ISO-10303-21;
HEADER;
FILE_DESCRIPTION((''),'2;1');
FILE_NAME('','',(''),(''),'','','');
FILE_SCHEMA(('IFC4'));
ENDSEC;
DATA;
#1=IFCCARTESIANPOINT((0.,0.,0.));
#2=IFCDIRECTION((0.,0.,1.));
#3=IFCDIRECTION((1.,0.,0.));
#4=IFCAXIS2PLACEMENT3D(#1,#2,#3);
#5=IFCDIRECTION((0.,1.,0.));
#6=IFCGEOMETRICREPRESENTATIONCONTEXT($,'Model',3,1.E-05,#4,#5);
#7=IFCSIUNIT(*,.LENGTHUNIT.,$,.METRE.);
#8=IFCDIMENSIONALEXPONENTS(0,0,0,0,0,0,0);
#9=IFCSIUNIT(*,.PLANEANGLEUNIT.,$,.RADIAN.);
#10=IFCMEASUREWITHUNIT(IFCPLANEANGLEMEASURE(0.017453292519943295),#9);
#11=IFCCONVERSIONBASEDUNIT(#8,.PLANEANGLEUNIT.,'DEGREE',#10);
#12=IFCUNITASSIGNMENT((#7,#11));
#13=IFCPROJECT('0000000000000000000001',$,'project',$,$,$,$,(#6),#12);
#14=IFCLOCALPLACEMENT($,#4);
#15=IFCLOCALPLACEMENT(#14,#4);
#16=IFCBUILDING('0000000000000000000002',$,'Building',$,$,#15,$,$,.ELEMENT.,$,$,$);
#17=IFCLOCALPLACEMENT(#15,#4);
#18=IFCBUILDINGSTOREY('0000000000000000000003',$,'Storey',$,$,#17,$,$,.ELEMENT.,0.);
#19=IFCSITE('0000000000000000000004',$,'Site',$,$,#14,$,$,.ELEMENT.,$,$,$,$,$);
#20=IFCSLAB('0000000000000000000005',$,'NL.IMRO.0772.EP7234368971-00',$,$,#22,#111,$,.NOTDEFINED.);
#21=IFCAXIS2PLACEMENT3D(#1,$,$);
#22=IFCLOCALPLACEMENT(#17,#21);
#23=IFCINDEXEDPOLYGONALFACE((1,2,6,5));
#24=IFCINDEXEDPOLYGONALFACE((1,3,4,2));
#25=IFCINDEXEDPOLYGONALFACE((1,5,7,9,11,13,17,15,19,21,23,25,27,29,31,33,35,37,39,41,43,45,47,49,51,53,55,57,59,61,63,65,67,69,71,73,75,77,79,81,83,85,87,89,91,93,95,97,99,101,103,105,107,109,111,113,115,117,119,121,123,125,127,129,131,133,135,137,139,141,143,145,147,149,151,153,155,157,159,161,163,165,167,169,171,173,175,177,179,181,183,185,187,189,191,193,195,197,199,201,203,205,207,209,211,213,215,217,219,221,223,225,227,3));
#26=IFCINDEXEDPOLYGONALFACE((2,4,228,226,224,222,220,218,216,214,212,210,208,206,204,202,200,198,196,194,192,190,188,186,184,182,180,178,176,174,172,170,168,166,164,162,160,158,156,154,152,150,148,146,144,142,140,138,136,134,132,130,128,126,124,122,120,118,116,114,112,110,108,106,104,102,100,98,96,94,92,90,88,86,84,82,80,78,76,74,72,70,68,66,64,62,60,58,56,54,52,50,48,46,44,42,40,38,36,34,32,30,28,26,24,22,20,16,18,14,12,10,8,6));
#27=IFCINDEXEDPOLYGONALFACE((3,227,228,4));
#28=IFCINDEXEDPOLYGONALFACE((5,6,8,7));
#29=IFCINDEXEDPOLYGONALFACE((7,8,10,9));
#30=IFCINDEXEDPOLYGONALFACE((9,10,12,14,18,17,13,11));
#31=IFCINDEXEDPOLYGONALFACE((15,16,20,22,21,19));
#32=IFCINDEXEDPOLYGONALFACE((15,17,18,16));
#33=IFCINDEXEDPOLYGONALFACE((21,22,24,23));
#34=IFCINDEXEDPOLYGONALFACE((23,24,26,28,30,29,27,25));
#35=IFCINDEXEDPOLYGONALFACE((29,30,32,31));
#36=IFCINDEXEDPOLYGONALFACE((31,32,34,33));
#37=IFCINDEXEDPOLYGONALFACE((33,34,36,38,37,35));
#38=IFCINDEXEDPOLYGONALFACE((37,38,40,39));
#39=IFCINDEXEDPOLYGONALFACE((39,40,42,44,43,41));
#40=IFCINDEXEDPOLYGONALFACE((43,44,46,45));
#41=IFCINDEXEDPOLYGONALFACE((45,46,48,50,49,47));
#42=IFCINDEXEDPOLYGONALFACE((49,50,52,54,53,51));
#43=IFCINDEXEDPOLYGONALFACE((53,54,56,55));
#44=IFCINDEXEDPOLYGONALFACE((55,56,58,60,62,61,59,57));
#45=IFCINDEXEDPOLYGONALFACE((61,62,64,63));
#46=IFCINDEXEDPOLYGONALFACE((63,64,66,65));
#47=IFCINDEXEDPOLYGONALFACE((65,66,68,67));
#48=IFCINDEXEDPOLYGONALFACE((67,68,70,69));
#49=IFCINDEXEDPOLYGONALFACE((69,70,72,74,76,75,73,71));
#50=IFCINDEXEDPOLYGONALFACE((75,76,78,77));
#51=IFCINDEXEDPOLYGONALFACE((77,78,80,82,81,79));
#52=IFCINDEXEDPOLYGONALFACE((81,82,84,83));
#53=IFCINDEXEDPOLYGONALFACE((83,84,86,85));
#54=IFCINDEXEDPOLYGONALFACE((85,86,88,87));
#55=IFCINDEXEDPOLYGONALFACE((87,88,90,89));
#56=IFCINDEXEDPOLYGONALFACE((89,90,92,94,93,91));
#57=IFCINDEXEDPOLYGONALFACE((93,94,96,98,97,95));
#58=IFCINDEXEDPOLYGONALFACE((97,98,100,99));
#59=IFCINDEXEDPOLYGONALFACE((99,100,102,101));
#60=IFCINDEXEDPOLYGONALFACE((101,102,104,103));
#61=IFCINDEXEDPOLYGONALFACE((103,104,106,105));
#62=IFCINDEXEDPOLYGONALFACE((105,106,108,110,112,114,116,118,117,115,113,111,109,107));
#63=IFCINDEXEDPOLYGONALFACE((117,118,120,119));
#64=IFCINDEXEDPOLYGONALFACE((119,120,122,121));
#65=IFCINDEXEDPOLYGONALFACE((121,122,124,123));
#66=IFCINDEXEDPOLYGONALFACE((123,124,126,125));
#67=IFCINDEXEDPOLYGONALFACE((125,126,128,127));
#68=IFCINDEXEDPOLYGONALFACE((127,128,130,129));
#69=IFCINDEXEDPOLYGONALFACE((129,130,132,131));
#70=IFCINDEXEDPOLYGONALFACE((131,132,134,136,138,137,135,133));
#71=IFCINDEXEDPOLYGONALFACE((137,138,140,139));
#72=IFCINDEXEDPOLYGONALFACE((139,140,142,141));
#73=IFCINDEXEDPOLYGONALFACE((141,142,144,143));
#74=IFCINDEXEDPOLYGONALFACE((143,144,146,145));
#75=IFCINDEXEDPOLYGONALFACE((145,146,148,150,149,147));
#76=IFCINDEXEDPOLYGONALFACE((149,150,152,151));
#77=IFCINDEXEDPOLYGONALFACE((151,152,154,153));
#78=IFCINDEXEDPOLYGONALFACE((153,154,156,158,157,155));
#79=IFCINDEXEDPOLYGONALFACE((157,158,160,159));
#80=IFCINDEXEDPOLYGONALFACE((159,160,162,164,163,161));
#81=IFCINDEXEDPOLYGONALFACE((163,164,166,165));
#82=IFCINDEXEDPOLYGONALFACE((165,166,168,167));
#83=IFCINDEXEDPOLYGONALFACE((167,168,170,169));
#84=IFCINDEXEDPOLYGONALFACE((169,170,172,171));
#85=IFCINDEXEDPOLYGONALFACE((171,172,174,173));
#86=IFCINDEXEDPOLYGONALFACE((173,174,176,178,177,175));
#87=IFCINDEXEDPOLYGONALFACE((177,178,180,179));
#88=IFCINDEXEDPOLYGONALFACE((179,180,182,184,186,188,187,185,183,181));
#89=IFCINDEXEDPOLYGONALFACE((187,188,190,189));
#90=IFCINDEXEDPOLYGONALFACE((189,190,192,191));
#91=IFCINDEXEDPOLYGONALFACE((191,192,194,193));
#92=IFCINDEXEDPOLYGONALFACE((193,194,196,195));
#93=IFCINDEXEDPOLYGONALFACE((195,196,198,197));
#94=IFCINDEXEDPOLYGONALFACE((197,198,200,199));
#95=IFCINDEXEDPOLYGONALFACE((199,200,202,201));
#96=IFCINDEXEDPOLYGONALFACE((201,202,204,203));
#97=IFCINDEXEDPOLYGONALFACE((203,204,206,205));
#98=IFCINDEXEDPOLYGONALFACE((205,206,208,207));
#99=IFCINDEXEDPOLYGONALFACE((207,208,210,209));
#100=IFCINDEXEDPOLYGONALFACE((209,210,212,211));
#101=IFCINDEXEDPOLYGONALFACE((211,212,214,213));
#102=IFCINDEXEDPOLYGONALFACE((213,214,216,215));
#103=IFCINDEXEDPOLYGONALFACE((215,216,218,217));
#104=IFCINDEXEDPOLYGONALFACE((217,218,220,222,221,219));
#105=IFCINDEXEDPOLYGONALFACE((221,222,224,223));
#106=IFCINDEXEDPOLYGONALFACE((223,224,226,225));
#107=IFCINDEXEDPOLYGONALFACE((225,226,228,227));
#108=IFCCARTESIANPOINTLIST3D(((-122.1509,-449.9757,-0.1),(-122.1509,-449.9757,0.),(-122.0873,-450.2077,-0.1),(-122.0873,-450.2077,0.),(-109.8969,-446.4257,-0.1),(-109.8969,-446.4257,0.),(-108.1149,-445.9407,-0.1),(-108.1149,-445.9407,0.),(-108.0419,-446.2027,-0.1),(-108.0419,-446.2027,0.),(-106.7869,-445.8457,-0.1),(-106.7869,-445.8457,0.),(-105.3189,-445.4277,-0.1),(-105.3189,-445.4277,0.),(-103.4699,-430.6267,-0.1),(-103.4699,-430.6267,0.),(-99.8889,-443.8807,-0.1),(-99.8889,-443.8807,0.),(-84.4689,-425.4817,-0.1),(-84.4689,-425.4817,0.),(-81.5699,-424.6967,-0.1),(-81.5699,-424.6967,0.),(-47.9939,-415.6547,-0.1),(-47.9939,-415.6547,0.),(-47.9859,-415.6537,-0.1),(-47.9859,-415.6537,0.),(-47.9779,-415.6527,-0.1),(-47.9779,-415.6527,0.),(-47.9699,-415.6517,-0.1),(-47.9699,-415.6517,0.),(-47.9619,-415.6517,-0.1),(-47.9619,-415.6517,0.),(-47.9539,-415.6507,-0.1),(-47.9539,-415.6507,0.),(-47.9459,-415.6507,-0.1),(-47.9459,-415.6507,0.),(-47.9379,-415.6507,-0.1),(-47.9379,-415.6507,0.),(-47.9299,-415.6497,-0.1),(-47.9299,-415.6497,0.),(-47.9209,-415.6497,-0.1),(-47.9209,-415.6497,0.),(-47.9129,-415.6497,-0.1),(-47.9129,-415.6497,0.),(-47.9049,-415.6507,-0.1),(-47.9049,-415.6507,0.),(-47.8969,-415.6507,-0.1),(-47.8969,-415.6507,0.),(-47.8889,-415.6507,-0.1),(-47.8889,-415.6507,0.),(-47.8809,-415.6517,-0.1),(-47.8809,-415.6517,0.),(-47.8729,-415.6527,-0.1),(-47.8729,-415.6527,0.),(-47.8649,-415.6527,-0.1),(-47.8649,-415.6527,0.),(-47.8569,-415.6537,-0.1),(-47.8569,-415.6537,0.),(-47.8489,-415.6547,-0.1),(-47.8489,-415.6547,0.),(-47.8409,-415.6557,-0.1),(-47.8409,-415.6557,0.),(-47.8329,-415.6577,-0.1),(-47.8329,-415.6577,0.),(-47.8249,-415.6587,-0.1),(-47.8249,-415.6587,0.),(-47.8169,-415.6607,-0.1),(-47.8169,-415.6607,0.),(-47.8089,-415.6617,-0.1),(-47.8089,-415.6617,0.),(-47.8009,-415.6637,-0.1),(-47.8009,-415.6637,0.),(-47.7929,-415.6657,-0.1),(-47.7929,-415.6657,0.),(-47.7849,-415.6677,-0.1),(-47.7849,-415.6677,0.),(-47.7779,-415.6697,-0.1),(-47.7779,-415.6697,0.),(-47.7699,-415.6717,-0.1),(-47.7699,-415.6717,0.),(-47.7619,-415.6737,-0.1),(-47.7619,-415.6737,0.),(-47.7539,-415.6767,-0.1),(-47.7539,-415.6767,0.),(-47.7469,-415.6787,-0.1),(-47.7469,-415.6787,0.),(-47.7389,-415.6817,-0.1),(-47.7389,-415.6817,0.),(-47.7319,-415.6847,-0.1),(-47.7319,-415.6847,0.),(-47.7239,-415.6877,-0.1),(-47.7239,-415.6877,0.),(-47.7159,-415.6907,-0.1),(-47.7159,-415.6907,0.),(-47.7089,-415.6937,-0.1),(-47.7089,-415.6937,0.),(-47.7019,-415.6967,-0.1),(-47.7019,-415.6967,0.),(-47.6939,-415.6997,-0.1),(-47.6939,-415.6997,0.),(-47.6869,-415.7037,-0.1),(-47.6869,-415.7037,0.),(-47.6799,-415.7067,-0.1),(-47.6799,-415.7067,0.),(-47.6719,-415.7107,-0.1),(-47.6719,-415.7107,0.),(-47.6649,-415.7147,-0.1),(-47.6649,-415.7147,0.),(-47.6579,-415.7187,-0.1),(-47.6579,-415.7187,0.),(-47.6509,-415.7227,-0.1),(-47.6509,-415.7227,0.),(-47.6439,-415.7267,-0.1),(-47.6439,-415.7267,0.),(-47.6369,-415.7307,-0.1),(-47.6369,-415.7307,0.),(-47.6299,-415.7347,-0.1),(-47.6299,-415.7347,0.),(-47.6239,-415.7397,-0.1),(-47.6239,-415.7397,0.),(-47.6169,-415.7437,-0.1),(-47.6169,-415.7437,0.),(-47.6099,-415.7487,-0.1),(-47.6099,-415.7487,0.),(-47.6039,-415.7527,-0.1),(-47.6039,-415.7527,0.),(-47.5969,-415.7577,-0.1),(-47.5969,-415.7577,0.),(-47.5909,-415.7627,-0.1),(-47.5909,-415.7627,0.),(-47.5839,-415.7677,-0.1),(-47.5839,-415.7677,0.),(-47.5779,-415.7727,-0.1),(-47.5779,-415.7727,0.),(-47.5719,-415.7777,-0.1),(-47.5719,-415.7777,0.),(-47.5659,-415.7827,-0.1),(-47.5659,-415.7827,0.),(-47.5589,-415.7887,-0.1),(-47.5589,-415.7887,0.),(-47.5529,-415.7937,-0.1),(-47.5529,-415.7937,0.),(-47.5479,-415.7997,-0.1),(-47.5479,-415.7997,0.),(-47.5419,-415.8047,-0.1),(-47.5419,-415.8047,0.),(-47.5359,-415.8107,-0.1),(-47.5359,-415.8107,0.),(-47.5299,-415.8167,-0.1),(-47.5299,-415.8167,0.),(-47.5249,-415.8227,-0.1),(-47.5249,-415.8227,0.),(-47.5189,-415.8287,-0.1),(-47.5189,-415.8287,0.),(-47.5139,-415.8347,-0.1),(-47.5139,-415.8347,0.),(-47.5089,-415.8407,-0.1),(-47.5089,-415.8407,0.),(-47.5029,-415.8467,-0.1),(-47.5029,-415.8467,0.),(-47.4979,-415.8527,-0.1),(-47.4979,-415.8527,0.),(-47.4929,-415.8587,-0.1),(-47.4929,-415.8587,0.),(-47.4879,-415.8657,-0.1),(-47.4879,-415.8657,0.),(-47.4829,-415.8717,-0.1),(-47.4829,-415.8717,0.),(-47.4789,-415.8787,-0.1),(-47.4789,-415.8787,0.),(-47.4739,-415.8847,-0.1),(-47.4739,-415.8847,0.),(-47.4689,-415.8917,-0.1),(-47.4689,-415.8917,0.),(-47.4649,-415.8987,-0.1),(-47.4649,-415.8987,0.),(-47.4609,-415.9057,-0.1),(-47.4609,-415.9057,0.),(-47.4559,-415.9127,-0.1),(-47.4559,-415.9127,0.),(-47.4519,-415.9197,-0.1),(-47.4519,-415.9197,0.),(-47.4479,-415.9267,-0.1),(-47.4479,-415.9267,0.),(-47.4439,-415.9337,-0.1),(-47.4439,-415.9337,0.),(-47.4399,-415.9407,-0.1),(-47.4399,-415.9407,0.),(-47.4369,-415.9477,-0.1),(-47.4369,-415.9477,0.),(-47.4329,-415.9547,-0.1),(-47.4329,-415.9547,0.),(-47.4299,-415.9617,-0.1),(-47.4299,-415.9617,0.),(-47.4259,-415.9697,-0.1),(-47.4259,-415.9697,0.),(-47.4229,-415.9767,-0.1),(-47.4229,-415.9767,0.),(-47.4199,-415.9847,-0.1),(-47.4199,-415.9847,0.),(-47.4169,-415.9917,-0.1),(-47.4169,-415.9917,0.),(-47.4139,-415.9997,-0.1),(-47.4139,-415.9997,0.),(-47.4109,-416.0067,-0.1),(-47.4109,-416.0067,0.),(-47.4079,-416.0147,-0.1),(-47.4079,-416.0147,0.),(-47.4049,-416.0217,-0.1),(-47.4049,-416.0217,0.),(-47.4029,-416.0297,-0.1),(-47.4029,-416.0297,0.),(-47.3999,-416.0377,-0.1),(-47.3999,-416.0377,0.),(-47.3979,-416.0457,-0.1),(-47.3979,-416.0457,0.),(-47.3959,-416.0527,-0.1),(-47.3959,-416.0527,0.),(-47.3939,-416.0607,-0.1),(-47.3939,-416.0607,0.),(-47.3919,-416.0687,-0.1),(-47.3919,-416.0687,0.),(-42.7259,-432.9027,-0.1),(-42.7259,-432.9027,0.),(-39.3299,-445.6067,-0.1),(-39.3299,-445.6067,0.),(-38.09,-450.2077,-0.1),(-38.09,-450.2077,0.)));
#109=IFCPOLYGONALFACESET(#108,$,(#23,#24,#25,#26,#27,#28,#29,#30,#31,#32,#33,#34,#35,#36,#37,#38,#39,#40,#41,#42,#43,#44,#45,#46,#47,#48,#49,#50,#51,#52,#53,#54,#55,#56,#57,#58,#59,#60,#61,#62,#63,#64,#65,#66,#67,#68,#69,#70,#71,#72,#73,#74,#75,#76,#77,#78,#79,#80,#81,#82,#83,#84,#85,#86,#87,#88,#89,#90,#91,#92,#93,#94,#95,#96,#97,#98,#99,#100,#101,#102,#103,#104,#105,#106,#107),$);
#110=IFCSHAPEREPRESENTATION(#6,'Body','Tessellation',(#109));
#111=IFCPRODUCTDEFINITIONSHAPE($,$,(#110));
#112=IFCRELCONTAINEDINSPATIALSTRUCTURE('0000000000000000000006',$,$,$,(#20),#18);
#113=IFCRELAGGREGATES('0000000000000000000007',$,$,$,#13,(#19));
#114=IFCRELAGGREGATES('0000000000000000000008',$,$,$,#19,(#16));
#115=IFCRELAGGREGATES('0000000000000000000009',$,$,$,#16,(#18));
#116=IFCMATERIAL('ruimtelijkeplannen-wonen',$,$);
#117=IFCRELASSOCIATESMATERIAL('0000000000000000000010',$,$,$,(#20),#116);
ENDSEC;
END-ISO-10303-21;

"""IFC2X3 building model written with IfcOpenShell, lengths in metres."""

from ifc_helpers import new_model, entity, si_unit, converted_unit, direction, frame, origin_with_axes, place, context, project, spatial, polyline, outline, extrude, material, element, save


model = new_model("IFC2X3")

# Units and contexts
model_context = context("Model", 3, precision=1e-05, world=origin_with_axes(), true_north=direction((0.0, 1.0, 0.0)))
ifc_project = project(units=[si_unit("LENGTHUNIT", "METRE"), converted_unit("PLANEANGLEUNIT", "DEGREE", entity("IfcPlaneAngleMeasure", 0.017453292519943295), si_unit("PLANEANGLEUNIT", "RADIAN"), dimensions=[0, 0, 0, 0, 0, 0, 0])], contexts=[model_context])

# Site, building, storey
site_placement = place(None, origin_with_axes())
site = spatial("IfcSite", under=ifc_project, at=site_placement, Name="Site", CompositionType="ELEMENT")
building_placement = place(site_placement, origin_with_axes())
building = spatial("IfcBuilding", under=site, at=building_placement, Name="Building", CompositionType="ELEMENT")
storey_placement = place(building_placement, origin_with_axes())
storey = spatial("IfcBuildingStorey", under=building, at=storey_placement, Name="Storey", CompositionType="ELEMENT", Elevation=0.0)

# Slab
ifc_material_1 = material(Name="ruimtelijkeplannen-wonen")
slab_1_placement = place(storey_placement, frame((0.0, 0.0, -0.1), z_axis=(0.0, 0.0, 1.0), x_axis=(1.0, 0.0, 0.0)))
element("IfcSlab", 1, at=slab_1_placement, inside=storey, material=ifc_material_1, Name="NL.IMRO.0772.EP7234368971-00", PredefinedType="NOTDEFINED", context=model_context, shape_type="SweptSolid", body=[
    extrude(outline(polyline([(-122.1509, -449.9757), (-109.8969, -446.4257), (-108.1149, -445.9407), (-108.0419, -446.2027), (-106.7869, -445.8457), (-105.3189, -445.4277), (-99.8889, -443.8807), (-103.4699, -430.6267), (-84.4689, -425.4817), (-81.5699, -424.6967), (-47.9939, -415.6547), (-47.9859, -415.6537), (-47.9779, -415.6527), (-47.9699, -415.6517), (-47.9619, -415.6517), (-47.9539, -415.6507), (-47.9459, -415.6507), (-47.9379, -415.6507), (-47.9299, -415.6497), (-47.9209, -415.6497), (-47.9129, -415.6497), (-47.9049, -415.6507), (-47.8969, -415.6507), (-47.8889, -415.6507), (-47.8809, -415.6517), (-47.8729, -415.6527), (-47.8649, -415.6527), (-47.8569, -415.6537), (-47.8489, -415.6547), (-47.8409, -415.6557), (-47.8329, -415.6577), (-47.8249, -415.6587), (-47.8169, -415.6607), (-47.8089, -415.6617), (-47.8009, -415.6637), (-47.7929, -415.6657), (-47.7849, -415.6677), (-47.7779, -415.6697), (-47.7699, -415.6717), (-47.7619, -415.6737), (-47.7539, -415.6767), (-47.7469, -415.6787), (-47.7389, -415.6817), (-47.7319, -415.6847), (-47.7239, -415.6877), (-47.7159, -415.6907), (-47.7089, -415.6937), (-47.7019, -415.6967), (-47.6939, -415.6997), (-47.6869, -415.7037), (-47.6799, -415.7067), (-47.6719, -415.7107), (-47.6649, -415.7147), (-47.6579, -415.7187), (-47.6509, -415.7227), (-47.6439, -415.7267), (-47.6369, -415.7307), (-47.6299, -415.7347), (-47.6239, -415.7397), (-47.6169, -415.7437), (-47.6099, -415.7487), (-47.6039, -415.7527), (-47.5969, -415.7577), (-47.5909, -415.7627), (-47.5839, -415.7677), (-47.5779, -415.7727), (-47.5719, -415.7777), (-47.5659, -415.7827), (-47.5589, -415.7887), (-47.5529, -415.7937), (-47.5479, -415.7997), (-47.5419, -415.8047), (-47.5359, -415.8107), (-47.5299, -415.8167), (-47.5249, -415.8227), (-47.5189, -415.8287), (-47.5139, -415.8347), (-47.5089, -415.8407), (-47.5029, -415.8467), (-47.4979, -415.8527), (-47.4929, -415.8587), (-47.4879, -415.8657), (-47.4829, -415.8717), (-47.4789, -415.8787), (-47.4739, -415.8847), (-47.4689, -415.8917), (-47.4649, -415.8987), (-47.4609, -415.9057), (-47.4559, -415.9127), (-47.4519, -415.9197), (-47.4479, -415.9267), (-47.4439, -415.9337), (-47.4399, -415.9407), (-47.4369, -415.9477), (-47.4329, -415.9547), (-47.4299, -415.9617), (-47.4259, -415.9697), (-47.4229, -415.9767), (-47.4199, -415.9847), (-47.4169, -415.9917), (-47.4139, -415.9997), (-47.4109, -416.0067), (-47.4079, -416.0147), (-47.4049, -416.0217), (-47.4029, -416.0297), (-47.3999, -416.0377), (-47.3979, -416.0457), (-47.3959, -416.0527), (-47.3939, -416.0607), (-47.3919, -416.0687), (-42.7259, -432.9027), (-39.3299, -445.6067), (-38.09, -450.2077), (-122.0873, -450.2077), (-122.1509, -449.9757)])), origin_with_axes(), (0.0, 0.0, 1.0), 0.1),
])

save(model, "model.ifc")
